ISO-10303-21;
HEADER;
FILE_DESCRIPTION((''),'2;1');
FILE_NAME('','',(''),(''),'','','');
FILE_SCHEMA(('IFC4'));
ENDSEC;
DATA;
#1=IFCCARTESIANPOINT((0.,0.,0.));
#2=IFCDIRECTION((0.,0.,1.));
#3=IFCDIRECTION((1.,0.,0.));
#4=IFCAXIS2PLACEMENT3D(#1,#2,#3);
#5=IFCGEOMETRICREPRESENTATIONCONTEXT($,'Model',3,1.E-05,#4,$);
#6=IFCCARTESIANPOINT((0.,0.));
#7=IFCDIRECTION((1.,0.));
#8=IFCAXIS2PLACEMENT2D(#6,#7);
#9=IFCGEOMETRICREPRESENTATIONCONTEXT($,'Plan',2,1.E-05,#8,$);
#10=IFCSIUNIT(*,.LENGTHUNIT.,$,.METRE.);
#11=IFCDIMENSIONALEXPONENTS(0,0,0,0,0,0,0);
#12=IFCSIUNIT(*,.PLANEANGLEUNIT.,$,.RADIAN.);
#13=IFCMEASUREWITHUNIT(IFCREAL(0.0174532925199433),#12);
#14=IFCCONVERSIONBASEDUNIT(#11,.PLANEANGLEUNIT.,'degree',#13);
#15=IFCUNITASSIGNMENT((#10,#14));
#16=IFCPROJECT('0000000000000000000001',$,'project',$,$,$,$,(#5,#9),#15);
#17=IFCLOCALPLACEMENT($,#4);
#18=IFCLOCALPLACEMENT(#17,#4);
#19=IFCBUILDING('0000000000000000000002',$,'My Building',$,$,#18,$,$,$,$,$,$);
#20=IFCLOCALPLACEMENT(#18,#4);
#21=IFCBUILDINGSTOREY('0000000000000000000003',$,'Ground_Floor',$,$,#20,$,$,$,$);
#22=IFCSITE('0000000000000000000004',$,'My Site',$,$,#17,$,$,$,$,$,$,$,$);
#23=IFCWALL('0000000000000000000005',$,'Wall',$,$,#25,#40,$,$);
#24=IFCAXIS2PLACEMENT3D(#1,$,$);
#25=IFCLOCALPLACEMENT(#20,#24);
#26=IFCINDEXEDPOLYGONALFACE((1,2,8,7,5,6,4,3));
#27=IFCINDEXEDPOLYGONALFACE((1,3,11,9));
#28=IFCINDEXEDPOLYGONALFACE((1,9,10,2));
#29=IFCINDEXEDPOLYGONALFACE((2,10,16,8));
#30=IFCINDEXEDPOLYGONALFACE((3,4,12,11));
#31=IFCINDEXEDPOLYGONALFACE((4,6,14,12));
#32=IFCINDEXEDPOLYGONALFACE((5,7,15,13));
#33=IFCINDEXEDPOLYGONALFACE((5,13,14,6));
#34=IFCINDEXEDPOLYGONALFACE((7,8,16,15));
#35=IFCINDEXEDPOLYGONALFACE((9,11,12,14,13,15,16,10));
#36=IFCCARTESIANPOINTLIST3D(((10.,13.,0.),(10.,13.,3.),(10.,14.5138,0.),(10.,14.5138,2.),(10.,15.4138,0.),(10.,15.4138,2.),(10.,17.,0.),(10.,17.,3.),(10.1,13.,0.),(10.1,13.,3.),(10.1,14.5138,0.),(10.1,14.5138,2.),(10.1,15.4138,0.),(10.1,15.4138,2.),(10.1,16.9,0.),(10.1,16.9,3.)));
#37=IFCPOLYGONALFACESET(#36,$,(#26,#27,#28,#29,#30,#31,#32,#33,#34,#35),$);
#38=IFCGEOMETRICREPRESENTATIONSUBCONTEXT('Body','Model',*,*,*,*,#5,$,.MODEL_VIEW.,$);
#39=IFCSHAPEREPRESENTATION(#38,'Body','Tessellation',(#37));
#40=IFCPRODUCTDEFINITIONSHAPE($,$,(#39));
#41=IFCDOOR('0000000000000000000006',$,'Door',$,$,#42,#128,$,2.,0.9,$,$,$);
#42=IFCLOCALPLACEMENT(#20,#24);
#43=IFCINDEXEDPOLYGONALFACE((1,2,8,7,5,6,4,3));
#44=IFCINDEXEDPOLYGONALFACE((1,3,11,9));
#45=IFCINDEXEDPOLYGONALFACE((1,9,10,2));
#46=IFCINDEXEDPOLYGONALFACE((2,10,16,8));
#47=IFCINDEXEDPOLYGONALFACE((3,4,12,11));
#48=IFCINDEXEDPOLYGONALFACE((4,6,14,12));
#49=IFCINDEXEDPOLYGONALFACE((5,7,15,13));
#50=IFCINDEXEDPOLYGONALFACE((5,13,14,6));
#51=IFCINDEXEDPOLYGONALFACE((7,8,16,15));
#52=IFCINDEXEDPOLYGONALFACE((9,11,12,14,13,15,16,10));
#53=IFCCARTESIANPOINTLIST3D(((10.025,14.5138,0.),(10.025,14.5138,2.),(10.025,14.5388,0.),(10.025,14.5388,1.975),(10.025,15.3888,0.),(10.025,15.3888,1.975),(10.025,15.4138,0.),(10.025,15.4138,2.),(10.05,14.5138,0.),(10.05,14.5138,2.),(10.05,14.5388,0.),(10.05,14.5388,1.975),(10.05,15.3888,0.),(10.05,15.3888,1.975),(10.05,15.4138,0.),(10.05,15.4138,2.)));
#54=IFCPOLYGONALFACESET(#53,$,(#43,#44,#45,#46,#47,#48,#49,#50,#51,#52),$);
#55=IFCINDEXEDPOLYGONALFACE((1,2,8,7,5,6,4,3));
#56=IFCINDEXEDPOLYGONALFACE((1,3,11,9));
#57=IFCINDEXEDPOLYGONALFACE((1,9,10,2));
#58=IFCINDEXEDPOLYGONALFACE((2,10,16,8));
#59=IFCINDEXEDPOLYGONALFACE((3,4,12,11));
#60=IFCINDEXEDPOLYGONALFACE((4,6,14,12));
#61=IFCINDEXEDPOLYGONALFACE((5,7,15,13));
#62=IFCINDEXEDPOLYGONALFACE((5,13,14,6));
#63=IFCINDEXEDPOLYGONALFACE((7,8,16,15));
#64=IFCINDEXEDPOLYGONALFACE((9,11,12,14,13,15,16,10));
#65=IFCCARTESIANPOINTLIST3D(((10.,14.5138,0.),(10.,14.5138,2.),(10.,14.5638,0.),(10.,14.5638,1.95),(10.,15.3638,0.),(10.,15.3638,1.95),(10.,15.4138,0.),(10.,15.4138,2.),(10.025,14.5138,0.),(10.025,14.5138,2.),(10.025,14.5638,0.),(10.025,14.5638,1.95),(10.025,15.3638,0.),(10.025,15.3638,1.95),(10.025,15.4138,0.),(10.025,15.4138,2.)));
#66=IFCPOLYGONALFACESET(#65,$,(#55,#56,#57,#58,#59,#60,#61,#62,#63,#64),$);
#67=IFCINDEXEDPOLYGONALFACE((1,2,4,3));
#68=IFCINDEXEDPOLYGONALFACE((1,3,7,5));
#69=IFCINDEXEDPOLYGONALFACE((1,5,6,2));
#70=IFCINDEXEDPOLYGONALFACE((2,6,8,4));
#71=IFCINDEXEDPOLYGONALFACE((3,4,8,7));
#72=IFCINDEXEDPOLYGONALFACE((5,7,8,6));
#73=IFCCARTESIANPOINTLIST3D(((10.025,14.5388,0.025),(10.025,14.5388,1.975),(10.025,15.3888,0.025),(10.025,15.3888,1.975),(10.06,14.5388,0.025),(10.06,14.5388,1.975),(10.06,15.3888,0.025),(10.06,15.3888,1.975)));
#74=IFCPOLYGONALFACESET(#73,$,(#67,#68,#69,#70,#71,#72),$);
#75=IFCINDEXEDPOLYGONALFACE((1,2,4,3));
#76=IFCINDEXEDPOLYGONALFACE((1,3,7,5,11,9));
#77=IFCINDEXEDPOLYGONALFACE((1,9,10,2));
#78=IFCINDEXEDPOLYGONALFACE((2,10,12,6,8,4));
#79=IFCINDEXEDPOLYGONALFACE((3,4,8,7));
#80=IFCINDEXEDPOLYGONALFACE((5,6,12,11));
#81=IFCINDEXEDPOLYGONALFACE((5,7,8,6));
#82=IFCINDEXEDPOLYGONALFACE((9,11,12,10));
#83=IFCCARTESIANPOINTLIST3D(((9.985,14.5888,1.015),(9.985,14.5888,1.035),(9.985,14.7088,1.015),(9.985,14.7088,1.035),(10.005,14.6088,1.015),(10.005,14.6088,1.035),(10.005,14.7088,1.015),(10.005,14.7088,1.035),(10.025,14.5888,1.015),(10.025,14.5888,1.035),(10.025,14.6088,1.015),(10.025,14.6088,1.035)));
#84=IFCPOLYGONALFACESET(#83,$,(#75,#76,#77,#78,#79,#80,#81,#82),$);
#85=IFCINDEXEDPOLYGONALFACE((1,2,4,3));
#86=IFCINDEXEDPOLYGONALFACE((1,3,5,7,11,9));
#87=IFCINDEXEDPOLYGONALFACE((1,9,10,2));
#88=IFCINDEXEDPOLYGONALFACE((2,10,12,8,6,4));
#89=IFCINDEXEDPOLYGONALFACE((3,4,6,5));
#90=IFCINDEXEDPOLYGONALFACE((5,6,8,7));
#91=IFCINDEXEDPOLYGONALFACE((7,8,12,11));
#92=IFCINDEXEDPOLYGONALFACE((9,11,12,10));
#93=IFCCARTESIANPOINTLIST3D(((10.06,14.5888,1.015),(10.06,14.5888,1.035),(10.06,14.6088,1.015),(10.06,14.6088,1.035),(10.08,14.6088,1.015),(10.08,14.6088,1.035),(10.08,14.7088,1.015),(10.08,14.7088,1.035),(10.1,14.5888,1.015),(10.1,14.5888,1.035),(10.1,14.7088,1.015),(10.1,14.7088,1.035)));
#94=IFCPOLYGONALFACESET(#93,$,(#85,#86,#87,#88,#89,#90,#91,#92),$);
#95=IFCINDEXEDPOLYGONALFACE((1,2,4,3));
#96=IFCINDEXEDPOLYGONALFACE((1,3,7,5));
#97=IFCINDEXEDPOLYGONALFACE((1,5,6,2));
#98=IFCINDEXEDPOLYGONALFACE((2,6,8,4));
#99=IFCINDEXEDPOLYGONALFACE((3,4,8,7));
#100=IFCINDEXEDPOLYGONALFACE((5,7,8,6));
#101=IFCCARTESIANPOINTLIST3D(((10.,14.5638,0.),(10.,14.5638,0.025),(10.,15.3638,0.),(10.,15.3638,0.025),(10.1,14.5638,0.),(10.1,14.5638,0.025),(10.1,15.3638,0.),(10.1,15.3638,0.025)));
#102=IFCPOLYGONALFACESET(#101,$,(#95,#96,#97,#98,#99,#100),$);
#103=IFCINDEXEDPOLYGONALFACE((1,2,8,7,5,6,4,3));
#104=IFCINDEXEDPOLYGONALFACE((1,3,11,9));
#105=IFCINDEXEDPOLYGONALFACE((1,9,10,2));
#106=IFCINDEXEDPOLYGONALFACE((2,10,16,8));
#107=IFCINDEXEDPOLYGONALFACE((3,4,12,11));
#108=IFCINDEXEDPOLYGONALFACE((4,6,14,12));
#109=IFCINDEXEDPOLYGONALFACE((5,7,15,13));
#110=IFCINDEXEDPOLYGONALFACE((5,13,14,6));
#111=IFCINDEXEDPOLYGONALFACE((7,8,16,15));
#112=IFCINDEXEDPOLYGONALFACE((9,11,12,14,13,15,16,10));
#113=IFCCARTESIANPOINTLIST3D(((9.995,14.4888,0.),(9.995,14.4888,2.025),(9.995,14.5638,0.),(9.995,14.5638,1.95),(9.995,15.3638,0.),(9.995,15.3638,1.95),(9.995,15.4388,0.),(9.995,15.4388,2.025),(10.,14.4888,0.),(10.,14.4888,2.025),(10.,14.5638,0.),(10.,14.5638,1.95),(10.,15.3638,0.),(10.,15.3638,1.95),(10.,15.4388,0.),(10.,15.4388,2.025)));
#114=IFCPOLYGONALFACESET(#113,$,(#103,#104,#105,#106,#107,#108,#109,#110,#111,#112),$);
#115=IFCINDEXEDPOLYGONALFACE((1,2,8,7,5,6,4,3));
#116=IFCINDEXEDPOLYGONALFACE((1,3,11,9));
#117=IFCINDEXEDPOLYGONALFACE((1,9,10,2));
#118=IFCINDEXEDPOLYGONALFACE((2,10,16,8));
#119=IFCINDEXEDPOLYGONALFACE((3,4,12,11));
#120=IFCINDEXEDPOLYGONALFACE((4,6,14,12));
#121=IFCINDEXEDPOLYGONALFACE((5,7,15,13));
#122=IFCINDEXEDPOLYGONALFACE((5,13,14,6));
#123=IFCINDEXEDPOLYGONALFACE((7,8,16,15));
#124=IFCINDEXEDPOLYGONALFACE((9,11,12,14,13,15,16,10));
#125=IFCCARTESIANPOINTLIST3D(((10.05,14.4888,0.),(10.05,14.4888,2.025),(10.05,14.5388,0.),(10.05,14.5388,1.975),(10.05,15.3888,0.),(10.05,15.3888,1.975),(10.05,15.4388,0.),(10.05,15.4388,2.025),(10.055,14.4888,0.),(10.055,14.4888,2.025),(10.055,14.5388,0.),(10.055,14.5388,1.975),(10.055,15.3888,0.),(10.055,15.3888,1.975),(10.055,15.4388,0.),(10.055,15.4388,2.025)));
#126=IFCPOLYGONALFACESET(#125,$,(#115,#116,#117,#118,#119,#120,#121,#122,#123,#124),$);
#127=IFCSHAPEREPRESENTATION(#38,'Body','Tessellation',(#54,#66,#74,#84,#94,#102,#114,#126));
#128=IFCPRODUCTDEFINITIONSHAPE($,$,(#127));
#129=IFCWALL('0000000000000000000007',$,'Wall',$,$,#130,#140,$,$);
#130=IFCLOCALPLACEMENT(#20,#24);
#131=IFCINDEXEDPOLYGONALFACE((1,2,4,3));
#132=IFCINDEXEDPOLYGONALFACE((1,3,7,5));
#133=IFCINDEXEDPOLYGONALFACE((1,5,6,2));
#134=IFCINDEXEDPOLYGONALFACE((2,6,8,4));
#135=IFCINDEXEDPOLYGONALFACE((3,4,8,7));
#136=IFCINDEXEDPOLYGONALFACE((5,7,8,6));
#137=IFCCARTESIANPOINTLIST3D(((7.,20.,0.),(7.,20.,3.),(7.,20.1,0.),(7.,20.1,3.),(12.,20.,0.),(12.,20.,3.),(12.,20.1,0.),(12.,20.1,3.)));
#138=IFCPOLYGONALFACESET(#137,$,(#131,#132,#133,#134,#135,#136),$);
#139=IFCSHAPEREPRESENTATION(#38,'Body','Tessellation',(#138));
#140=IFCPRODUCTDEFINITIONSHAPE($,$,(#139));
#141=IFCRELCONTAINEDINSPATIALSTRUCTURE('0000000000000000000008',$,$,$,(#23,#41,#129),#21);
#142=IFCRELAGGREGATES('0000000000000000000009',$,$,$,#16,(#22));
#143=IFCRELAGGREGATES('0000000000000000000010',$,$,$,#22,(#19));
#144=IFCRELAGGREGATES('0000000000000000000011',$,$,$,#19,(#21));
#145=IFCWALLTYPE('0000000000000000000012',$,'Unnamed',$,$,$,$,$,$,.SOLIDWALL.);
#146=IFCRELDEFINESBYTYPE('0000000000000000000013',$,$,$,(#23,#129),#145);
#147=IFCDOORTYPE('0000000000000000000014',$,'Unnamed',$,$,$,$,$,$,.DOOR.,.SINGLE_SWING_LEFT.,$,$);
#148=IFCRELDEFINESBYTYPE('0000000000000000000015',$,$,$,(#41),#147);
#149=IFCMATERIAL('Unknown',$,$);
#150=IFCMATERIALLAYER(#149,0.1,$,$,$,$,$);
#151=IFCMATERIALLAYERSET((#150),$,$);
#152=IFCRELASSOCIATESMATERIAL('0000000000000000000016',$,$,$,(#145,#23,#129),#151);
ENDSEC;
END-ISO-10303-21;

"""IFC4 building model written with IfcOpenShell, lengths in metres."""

from ifc_helpers import new_model, entity, si_unit, converted_unit, frame, origin_with_axes, origin_2d_with_axis, place, context, subcontext, project, spatial, line, indexed_curve, outline, extrude, shape, source, transform, mapped, material, layer, layer_set, layer_usage, type_object, type_shapes, element, fill, save


model = new_model("IFC4")

# Units and contexts
model_context = context("Model", 3, precision=1e-05, world=origin_with_axes())
plan_context = context("Plan", 2, precision=1e-05, world=origin_2d_with_axis())
body_context_1 = subcontext(model_context, "Body", "Model", "MODEL_VIEW")
body_context_2 = subcontext(plan_context, "Body", "Plan", "PLAN_VIEW")
ifc_project = project(units=[si_unit("LENGTHUNIT", "METRE"), converted_unit("PLANEANGLEUNIT", "degree", entity("IfcReal", 0.0174532925199433), si_unit("PLANEANGLEUNIT", "RADIAN"), dimensions=[0, 0, 0, 0, 0, 0, 0])], contexts=[model_context, plan_context])

# Site, building, storey
site_placement = place(None, origin_with_axes())
site = spatial("IfcSite", under=ifc_project, at=site_placement, Name="My Site")
building_placement = place(site_placement, origin_with_axes())
building = spatial("IfcBuilding", under=site, at=building_placement, Name="My Building")
storey_placement = place(building_placement, origin_with_axes())
storey = spatial("IfcBuildingStorey", under=building, at=storey_placement, Name="Ground_Floor")

# Shared definitions
ifc_material = material(Name="Unknown")

# Shared definitions
ifc_layer_1 = layer(ifc_material, 0.1)
ifc_layer_set_1 = layer_set([ifc_layer_1])
wall_type = type_object("IfcWallType", Name="Unnamed", PredefinedType="SOLIDWALL", material=ifc_layer_set_1)

# Shared definitions
shared_shape_1 = source(origin_with_axes(), body_context_1, "Body", "SweptSolid", [
    extrude(outline(indexed_curve([(0.0, 0.0), (0.9, 0.0), (0.9, 2.0), (0.0, 2.0)], segments=[line(1, 2, 3, 4, 1)])), frame((0.0, -0.6, 0.0), z_axis=(0.0, -1.0, 0.0), x_axis=(1.0, 0.0, 0.0)), (0.0, 0.0, -1.0), 1.2),
])
door_type_1 = type_object("IfcDoorType", Name="Unnamed", OperationType="SINGLE_SWING_LEFT", PredefinedType="DOOR")
shared_shape_2 = source(origin_with_axes(), body_context_1, "Body", "SweptSolid", [
    extrude(outline(indexed_curve([(0.0, 0.0), (0.0, 2.0), (0.9, 2.0), (0.9, 0.0), (0.875, 0.0), (0.875, 1.975), (0.025, 1.975), (0.025, 0.0)], segments=[line(1, 2, 3, 4, 5, 6, 7, 8, 1)])), frame((0.0, 0.025, 0.0), z_axis=(0.0, -1.0, 0.0), x_axis=(1.0, 0.0, 0.0)), (0.0, 0.0, -1.0), 0.025),
    extrude(outline(indexed_curve([(0.0, 0.0), (0.0, 2.0), (0.9, 2.0), (0.9, 0.0), (0.85, 0.0), (0.85, 1.95), (0.05, 1.95), (0.05, 0.0)], segments=[line(1, 2, 3, 4, 5, 6, 7, 8, 1)])), frame((0.0, 0.0, 0.0), z_axis=(0.0, -1.0, 0.0), x_axis=(1.0, 0.0, 0.0)), (0.0, 0.0, -1.0), 0.025),
    extrude(outline(indexed_curve([(0.0, 0.0), (0.85, 0.0), (0.85, 0.035), (0.0, 0.035)], segments=[line(1, 2, 3, 4, 1)])), frame((0.025, 0.025, 0.025), z_axis=(0.0, 0.0, 1.0), x_axis=(1.0, 0.0, 0.0)), (0.0, 0.0, 1.0), 1.95),
    extrude(outline(indexed_curve([(0.0, 0.0), (0.0, -0.04), (-0.12, -0.04), (-0.12, -0.02), (-0.02, -0.02), (-0.02, 0.0)], segments=[line(1, 2, 3, 4, 5, 6, 1)])), frame((0.825, 0.025, 1.015), z_axis=(0.0, 0.0, 1.0), x_axis=(1.0, 0.0, 0.0)), (0.0, 0.0, 1.0), 0.02),
    extrude(outline(indexed_curve([(0.0, 0.0), (0.0, 0.04), (-0.12, 0.04), (-0.12, 0.02), (-0.02, 0.02), (-0.02, 0.0)], segments=[line(1, 2, 3, 4, 5, 6, 1)])), frame((0.825, 0.06, 1.015), z_axis=(0.0, 0.0, 1.0), x_axis=(1.0, 0.0, 0.0)), (0.0, 0.0, 1.0), 0.02),
    extrude(outline(indexed_curve([(0.0, 0.0), (0.8, 0.0), (0.8, 0.1), (0.0, 0.1)], segments=[line(1, 2, 3, 4, 1)])), frame((0.05, 0.0, 0.0), z_axis=(0.0, 0.0, 1.0), x_axis=(1.0, 0.0, 0.0)), (0.0, 0.0, 1.0), 0.025),
    extrude(outline(indexed_curve([(0.0, 0.0), (0.0, 2.025), (0.95, 2.025), (0.95, 0.0), (0.875, 0.0), (0.875, 1.95), (0.075, 1.95), (0.075, 0.0)], segments=[line(1, 2, 3, 4, 5, 6, 7, 8, 1)])), frame((-0.025, -0.005, 0.0), z_axis=(0.0, -1.0, 0.0), x_axis=(1.0, 0.0, 0.0)), (0.0, 0.0, -1.0), 0.005),
    extrude(outline(indexed_curve([(0.0, 0.0), (0.0, 2.025), (0.95, 2.025), (0.95, 0.0), (0.9, 0.0), (0.9, 1.975), (0.05, 1.975), (0.05, 0.0)], segments=[line(1, 2, 3, 4, 5, 6, 7, 8, 1)])), frame((-0.025, 0.05, 0.0), z_axis=(0.0, -1.0, 0.0), x_axis=(1.0, 0.0, 0.0)), (0.0, 0.0, -1.0), 0.005),
])
shared_shape_3 = source(origin_with_axes(), body_context_2, "Body", "Curve2D", [
    entity("IfcIndexedPolyCurve", entity("IfcCartesianPointList2D", [[0.0, 0.0], [0.0, 0.05], [0.025, 0.05], [0.025, 0.025], [0.05, 0.025], [0.05, 0.0]]), [entity("IfcLineIndex", [1, 2, 3, 4, 5, 6, 1])]),
    entity("IfcIndexedPolyCurve", entity("IfcCartesianPointList2D", [[0.9, 0.0], [0.9, 0.05], [0.875, 0.05], [0.875, 0.025], [0.85, 0.025], [0.85, 0.0]]), [entity("IfcLineIndex", [1, 2, 3, 4, 5, 6, 1])]),
    entity("IfcTrimmedCurve", entity("IfcEllipse", entity("IfcAxis2Placement2D", entity("IfcCartesianPoint", [0.06, 0.05]), entity("IfcDirection", [1.0, 0.0])), 0.815, 0.85), [entity("IfcCartesianPoint", [0.875, 0.05])], [entity("IfcCartesianPoint", [0.06, 0.9])], True, "CARTESIAN"),
    entity("IfcIndexedPolyCurve", entity("IfcCartesianPointList2D", [[0.025, 0.05], [0.06, 0.05], [0.06, 0.9], [0.025, 0.9]]), [entity("IfcLineIndex", [1, 2, 3, 4, 1])]),
])
type_shapes(door_type_1, [shared_shape_2, shared_shape_3])

# Wall, opening, door
ifc_layer_usage_1 = layer_usage(ifc_layer_set_1, "AXIS2", "POSITIVE", 0.0)
wall_1_placement = place(storey_placement, frame((10.0, 17.0, 0.0), z_axis=(0.0, 0.0, 1.0), x_axis=(0.0, -1.0, 0.0)))
wall_1 = element("IfcWall", 1, at=wall_1_placement, inside=storey, type_object=wall_type, material=ifc_layer_usage_1, Name="Wall", context=body_context_1, shape_type="SweptSolid", body=[
    extrude(outline(indexed_curve([(0.0, 0.0), (0.1, 0.1), (4.0, 0.1), (4.0, 0.0)], segments=[line(1, 2, 3, 4, 1)])), origin_with_axes(), (0.0, 0.0, 1.0), 3.0),
])
opening_1_placement = place(wall_1_placement, frame((1.5862, 0.0, 0.0), z_axis=(0.0, 0.0, 1.0), x_axis=(1.0, 0.0, 0.0)))
opening_1 = element("IfcOpeningElement", 2, at=opening_1_placement, cuts=wall_1, PredefinedType="OPENING", context=body_context_1, shape_type="MappedRepresentation", body=[
    mapped(shared_shape_1, transform((0.0, 0.0, 0.0), x_axis=(1.0, 0.0, 0.0), y_axis=(0.0, 1.0, 0.0), z_axis=(0.0, 0.0, 1.0), scale=1.0)),
])
door_1_placement = place(opening_1_placement, frame((0.0, 0.0, 0.0), z_axis=(0.0, 0.0, 1.0), x_axis=(1.0, 0.0, 0.0)))
door_1 = element("IfcDoor", 3, at=door_1_placement, inside=storey, type_object=door_type_1, Name="Door", OverallHeight=2.0, OverallWidth=0.9, shapes=[
    shape(body_context_1, "Body", "MappedRepresentation", [mapped(shared_shape_2, transform((0.0, 0.0, 0.0), x_axis=(1.0, 0.0, 0.0), y_axis=(0.0, 1.0, 0.0), z_axis=(0.0, 0.0, 1.0), scale=1.0))]),
    shape(body_context_2, "Body", "MappedRepresentation", [mapped(shared_shape_3, transform((0.0, 0.0, 0.0), x_axis=(1.0, 0.0, 0.0), y_axis=(0.0, 1.0, 0.0), z_axis=(0.0, 0.0, 1.0), scale=1.0))]),
])
fill(opening_1, door_1)

# Wall
ifc_layer_usage_2 = layer_usage(ifc_layer_set_1, "AXIS2", "POSITIVE", 0.0)
wall_2_placement = place(storey_placement, frame((7.0, 20.0, 0.0), z_axis=(0.0, 0.0, 1.0), x_axis=(1.0, 0.0, 0.0)))
element("IfcWall", 4, at=wall_2_placement, inside=storey, type_object=wall_type, material=ifc_layer_usage_2, Name="Wall", context=body_context_1, shape_type="SweptSolid", body=[
    extrude(outline(indexed_curve([(0.0, 0.0), (0.0, 0.1), (5.0, 0.1), (5.0, 0.0)], segments=[line(1, 2, 3, 4, 1)])), origin_with_axes(), (0.0, 0.0, 1.0), 3.0),
])

save(model, "model.ifc")
